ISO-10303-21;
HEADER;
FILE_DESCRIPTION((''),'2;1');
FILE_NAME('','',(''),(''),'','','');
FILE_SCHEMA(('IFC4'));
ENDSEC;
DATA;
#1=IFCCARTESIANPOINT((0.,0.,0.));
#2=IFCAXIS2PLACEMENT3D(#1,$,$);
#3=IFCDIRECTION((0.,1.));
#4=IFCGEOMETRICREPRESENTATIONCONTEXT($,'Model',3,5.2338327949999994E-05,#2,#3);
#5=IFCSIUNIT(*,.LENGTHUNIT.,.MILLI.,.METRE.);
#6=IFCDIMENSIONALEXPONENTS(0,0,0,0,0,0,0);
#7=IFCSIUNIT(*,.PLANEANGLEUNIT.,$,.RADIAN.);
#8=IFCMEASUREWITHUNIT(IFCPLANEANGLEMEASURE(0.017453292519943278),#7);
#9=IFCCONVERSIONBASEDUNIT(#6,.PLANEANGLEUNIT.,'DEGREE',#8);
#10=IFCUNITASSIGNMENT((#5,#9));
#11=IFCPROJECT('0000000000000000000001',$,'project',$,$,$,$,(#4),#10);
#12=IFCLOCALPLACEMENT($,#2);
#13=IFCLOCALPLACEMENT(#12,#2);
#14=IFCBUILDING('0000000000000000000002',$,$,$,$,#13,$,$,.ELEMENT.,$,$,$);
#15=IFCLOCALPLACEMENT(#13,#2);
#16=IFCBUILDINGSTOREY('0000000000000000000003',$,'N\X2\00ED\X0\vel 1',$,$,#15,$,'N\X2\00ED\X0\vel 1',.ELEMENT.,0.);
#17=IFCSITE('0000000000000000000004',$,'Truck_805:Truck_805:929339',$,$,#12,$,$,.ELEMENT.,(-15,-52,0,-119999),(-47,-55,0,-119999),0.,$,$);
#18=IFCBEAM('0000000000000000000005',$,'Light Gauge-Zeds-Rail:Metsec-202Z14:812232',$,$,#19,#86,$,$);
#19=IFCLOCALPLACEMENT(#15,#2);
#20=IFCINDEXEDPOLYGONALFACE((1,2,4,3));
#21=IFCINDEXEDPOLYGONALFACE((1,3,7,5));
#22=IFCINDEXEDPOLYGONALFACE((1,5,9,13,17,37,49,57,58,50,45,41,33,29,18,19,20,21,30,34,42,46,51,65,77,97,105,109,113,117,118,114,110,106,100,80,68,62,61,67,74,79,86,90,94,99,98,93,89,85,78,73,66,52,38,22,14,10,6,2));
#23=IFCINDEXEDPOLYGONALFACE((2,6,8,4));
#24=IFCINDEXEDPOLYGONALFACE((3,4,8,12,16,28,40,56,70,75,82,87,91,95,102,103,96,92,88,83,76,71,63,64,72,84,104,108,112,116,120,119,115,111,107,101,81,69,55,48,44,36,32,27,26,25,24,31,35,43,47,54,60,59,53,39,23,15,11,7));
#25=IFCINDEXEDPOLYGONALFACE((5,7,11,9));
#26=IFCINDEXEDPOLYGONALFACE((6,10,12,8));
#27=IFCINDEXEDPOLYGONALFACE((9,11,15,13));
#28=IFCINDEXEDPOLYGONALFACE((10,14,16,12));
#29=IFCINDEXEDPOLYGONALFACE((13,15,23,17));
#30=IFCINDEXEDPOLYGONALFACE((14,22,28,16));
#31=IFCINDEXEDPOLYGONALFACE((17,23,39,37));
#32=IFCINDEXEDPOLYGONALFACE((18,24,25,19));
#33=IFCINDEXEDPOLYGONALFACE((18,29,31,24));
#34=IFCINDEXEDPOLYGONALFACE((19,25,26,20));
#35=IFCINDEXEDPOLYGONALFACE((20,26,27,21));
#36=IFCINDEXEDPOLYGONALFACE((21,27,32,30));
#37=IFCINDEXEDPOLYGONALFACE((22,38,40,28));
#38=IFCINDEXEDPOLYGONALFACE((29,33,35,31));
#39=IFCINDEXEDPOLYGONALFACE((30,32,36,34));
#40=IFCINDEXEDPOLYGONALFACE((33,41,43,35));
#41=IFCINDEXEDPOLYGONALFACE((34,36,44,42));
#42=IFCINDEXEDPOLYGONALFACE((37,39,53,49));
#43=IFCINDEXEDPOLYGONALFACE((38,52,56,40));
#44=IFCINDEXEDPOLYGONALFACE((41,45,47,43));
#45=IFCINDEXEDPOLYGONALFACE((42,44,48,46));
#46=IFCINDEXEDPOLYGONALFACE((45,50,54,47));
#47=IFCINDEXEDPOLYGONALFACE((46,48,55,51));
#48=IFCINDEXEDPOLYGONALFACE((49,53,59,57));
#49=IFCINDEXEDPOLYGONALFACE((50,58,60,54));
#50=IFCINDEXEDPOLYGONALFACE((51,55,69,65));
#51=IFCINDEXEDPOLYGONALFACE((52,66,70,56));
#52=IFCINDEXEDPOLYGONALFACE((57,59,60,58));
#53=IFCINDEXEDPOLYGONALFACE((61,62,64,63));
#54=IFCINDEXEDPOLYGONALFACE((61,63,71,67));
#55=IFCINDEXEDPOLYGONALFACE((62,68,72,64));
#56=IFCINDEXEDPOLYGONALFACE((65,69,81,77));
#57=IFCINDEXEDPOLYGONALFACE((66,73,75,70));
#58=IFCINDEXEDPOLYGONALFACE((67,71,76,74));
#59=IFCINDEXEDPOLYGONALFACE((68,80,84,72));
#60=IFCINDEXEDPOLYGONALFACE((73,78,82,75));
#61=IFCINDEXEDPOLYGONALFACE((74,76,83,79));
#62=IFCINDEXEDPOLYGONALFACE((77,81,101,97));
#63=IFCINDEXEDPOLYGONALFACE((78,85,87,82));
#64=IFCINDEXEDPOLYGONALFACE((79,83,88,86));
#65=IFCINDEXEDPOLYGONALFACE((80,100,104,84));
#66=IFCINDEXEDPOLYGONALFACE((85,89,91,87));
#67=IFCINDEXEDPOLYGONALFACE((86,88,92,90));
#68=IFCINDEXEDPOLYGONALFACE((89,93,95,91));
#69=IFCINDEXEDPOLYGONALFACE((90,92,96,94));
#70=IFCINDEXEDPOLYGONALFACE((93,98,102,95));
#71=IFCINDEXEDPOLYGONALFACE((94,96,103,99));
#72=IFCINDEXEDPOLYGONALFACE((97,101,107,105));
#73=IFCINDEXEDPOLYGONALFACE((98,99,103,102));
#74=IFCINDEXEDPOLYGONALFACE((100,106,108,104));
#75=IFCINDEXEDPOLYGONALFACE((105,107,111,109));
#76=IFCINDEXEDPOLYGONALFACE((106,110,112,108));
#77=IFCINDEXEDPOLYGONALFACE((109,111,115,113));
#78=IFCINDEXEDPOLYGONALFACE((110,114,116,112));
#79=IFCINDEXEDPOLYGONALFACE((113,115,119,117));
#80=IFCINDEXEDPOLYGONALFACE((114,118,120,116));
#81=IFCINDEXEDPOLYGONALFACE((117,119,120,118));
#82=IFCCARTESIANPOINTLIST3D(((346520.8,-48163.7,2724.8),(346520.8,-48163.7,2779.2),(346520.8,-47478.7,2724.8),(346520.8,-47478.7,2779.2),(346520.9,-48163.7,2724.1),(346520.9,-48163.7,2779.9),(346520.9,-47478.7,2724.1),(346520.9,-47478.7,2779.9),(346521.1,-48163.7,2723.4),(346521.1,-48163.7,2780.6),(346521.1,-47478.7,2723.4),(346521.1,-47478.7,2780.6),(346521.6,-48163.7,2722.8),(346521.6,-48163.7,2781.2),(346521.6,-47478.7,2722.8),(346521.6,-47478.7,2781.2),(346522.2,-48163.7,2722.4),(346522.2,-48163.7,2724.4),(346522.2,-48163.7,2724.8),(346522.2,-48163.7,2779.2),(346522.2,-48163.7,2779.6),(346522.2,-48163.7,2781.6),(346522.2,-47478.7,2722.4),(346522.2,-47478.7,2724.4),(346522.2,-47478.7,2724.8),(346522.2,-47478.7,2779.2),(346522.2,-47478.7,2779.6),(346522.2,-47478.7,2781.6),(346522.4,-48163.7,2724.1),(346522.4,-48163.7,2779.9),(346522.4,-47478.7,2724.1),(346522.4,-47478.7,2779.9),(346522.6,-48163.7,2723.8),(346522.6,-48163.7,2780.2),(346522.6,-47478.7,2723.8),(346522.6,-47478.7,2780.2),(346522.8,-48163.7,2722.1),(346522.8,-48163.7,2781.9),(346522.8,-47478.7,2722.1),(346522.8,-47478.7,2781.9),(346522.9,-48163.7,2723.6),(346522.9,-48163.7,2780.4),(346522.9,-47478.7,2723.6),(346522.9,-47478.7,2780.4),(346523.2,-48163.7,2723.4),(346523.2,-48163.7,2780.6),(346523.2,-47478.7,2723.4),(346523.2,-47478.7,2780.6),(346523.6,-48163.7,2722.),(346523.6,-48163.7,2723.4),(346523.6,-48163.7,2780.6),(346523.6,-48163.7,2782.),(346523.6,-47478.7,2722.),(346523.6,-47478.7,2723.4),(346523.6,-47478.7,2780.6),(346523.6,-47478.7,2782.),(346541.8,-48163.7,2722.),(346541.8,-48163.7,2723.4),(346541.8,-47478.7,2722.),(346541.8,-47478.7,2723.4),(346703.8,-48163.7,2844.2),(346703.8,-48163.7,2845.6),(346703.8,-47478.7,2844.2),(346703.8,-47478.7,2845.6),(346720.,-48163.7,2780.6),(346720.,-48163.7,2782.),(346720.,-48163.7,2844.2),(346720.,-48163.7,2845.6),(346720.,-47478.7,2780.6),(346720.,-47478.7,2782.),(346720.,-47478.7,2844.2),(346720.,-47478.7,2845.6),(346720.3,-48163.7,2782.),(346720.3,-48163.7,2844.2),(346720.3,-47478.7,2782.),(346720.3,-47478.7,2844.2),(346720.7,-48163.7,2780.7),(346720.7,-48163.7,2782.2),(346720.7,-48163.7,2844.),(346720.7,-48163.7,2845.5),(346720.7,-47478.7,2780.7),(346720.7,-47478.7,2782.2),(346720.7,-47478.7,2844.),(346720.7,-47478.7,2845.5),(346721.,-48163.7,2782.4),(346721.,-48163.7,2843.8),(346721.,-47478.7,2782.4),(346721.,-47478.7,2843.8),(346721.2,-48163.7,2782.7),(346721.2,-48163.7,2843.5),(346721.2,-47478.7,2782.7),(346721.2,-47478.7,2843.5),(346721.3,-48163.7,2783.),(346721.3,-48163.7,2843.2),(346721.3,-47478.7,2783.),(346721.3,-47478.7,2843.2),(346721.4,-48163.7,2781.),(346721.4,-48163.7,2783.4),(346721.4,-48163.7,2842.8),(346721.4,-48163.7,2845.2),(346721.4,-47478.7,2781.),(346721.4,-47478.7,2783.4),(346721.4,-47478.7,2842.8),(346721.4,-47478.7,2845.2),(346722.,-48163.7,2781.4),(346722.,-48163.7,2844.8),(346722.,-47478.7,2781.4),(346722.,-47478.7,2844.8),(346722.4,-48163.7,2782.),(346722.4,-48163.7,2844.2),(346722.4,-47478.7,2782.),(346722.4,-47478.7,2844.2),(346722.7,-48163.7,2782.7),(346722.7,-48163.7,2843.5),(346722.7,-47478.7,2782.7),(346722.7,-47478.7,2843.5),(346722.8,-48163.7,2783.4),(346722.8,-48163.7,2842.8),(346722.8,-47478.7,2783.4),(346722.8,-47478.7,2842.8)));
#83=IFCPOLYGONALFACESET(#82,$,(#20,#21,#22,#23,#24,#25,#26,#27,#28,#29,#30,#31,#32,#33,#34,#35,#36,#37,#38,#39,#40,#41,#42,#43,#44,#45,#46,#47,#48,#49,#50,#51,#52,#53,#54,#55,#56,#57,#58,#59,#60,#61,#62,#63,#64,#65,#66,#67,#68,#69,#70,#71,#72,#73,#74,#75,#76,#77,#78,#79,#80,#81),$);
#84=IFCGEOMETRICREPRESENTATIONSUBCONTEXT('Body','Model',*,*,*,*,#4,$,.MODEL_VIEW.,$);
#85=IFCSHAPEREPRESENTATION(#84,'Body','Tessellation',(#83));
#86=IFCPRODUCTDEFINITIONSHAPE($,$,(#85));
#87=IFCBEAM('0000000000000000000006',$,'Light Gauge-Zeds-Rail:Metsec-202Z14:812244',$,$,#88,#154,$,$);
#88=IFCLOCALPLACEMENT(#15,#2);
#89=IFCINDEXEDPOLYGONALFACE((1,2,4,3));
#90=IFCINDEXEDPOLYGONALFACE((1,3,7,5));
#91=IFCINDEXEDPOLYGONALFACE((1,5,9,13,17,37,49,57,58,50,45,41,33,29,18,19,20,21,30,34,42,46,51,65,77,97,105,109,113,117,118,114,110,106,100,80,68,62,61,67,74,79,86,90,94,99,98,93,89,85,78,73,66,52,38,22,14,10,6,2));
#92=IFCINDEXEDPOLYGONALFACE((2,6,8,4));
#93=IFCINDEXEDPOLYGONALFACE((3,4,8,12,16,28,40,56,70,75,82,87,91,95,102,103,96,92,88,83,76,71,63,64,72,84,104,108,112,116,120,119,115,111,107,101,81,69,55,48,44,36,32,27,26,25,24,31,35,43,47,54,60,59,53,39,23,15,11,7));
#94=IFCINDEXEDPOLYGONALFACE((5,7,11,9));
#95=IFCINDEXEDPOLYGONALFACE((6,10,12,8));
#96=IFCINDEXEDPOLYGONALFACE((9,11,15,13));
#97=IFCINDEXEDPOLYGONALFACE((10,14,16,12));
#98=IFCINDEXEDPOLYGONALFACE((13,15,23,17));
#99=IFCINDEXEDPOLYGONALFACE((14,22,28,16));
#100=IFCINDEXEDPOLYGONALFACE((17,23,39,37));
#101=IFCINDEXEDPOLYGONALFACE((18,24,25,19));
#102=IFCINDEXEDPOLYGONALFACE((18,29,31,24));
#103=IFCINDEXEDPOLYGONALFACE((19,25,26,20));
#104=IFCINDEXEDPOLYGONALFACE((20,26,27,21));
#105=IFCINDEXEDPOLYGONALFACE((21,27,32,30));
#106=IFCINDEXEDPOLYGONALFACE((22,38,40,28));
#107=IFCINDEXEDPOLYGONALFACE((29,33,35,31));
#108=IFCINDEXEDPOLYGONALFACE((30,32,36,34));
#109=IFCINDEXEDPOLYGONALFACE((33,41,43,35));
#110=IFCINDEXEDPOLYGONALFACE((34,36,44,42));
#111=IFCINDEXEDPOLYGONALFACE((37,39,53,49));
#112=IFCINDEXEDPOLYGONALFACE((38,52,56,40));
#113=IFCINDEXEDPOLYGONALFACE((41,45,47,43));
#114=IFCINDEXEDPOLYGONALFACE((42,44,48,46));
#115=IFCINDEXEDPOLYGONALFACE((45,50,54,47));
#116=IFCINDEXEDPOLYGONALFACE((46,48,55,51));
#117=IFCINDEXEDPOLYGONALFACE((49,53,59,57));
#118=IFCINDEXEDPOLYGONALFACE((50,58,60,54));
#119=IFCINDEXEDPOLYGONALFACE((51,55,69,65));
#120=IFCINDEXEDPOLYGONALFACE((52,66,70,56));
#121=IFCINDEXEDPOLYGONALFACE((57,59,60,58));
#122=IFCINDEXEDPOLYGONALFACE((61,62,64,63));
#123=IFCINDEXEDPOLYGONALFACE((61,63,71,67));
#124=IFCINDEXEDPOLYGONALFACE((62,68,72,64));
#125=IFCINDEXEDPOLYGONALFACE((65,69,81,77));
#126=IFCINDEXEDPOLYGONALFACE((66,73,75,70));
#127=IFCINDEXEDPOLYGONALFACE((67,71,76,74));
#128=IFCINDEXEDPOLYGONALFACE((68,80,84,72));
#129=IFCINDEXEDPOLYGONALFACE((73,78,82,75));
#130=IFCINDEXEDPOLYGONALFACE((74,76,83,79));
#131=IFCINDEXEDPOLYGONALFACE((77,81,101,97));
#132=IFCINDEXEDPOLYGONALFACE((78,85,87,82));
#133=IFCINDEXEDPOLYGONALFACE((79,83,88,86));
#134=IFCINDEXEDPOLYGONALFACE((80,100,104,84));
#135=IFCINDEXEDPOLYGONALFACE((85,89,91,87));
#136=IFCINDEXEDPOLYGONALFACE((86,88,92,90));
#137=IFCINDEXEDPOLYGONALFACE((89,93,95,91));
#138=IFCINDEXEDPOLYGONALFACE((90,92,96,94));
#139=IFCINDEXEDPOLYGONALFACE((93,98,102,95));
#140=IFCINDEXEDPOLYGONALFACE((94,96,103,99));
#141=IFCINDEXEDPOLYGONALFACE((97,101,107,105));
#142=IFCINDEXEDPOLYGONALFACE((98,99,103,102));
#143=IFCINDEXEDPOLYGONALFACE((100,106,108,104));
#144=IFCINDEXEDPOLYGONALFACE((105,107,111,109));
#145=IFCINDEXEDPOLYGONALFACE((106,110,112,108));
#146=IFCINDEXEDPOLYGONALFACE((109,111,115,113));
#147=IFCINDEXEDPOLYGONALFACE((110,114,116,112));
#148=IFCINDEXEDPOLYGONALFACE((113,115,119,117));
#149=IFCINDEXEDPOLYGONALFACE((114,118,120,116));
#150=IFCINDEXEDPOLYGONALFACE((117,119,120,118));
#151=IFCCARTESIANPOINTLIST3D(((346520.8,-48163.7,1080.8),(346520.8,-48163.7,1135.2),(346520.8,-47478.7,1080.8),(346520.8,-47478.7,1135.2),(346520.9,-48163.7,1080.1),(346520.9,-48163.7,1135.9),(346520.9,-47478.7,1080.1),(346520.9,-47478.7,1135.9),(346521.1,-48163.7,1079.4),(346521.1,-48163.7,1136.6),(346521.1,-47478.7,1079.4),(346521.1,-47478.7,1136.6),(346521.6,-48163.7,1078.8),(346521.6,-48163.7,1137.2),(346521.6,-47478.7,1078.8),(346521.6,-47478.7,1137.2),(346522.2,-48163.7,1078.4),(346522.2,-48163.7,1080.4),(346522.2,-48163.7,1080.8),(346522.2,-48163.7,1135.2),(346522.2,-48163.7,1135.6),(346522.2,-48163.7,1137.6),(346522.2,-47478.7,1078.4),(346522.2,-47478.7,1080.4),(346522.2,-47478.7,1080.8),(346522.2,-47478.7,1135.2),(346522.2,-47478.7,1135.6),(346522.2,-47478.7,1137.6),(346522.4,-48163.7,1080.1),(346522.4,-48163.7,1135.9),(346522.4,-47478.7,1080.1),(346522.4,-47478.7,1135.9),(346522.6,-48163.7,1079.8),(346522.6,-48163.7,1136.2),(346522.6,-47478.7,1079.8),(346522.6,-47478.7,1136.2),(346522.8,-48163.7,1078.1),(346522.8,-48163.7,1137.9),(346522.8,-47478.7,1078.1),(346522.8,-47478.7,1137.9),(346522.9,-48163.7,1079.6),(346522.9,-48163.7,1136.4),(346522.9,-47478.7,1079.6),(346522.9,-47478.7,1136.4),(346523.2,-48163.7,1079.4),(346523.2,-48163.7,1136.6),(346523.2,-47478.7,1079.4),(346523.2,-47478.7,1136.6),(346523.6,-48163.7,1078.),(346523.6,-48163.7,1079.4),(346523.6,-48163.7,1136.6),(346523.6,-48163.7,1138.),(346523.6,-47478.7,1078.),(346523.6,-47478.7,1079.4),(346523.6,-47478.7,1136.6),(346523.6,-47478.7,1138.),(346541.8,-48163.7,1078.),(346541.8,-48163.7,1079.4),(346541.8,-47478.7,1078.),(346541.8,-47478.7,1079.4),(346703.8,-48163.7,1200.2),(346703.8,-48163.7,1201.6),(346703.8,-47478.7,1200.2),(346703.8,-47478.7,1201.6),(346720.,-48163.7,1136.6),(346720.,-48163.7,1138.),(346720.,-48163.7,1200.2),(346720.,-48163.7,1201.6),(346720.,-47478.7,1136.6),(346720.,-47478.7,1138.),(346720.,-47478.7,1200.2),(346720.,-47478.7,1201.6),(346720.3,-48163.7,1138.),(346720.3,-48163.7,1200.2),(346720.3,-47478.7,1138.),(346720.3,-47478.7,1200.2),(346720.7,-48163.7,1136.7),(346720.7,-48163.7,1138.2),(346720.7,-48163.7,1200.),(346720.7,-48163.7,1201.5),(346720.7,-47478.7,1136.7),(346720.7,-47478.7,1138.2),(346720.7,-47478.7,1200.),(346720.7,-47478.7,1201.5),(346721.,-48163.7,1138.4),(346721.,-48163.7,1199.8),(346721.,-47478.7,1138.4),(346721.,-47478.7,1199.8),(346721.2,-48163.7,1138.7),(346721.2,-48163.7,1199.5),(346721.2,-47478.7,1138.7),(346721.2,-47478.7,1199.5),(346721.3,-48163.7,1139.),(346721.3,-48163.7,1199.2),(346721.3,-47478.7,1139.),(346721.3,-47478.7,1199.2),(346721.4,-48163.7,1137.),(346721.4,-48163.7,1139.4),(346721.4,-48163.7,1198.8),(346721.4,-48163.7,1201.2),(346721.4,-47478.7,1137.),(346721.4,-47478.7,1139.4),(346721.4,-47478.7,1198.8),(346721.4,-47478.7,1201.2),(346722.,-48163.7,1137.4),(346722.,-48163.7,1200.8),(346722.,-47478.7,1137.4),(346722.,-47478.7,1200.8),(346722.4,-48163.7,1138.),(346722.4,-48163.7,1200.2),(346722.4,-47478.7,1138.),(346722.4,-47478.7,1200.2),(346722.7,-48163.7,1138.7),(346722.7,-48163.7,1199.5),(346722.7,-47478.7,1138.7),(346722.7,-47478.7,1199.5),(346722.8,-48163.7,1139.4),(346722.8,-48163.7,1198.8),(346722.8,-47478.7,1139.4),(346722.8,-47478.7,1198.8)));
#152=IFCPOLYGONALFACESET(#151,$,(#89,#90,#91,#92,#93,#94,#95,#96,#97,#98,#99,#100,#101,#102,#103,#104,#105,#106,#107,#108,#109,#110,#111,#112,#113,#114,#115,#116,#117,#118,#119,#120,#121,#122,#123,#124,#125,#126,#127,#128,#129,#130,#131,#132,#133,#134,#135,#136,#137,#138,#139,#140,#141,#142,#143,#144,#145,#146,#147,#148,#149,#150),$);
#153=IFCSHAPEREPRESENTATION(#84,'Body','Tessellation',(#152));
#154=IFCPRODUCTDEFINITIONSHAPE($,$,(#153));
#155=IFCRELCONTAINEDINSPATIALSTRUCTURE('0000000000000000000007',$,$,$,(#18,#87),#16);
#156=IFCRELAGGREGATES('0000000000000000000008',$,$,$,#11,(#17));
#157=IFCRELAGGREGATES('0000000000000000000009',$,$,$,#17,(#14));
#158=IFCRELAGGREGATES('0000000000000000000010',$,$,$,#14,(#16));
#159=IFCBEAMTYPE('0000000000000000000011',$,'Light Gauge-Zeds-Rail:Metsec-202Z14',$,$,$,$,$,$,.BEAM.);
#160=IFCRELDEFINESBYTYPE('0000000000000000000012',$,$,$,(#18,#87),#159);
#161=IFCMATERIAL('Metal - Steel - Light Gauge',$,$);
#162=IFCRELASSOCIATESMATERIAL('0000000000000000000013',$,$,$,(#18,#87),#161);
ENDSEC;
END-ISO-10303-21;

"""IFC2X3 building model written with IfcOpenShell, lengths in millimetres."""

from ifc_helpers import new_model, entity, si_unit, converted_unit, direction, frame, frame_2d, origin, place, context, subcontext, project, spatial, polyline, circle_curve, parameter, trimmed, segment, composite_curve, outline, extrude, material, type_object, element, save


model = new_model("IFC2X3")

# Units and contexts
model_context = context("Model", 3, precision=5.2338327949999994e-05, world=origin(), true_north=direction((0.0, 1.0)))
body_context = subcontext(model_context, "Body", "Model", "MODEL_VIEW")
ifc_project = project(units=[si_unit("LENGTHUNIT", "METRE", prefix="MILLI"), converted_unit("PLANEANGLEUNIT", "DEGREE", entity("IfcPlaneAngleMeasure", 0.017453292519943278), si_unit("PLANEANGLEUNIT", "RADIAN"), dimensions=[0, 0, 0, 0, 0, 0, 0])], contexts=[model_context])

# Site, building, storey
site_placement = place(None, origin())
site = spatial("IfcSite", under=ifc_project, at=site_placement, Name="Truck_805:Truck_805:929339", CompositionType="ELEMENT", RefLatitude=(-15, -52, 0, -119999), RefLongitude=(-47, -55, 0, -119999), RefElevation=0.0)
building_placement = place(site_placement, origin())
building = spatial("IfcBuilding", under=site, at=building_placement, CompositionType="ELEMENT")
storey_placement = place(building_placement, origin())
storey = spatial("IfcBuildingStorey", under=building, at=storey_placement, Name="Nível 1", LongName="Nível 1", CompositionType="ELEMENT", Elevation=0.0)

# Beams
ifc_material_1 = material(Name="Metal - Steel - Light Gauge")
beam_type_1 = type_object("IfcBeamType", Name="Light Gauge-Zeds-Rail:Metsec-202Z14", PredefinedType="BEAM")
beam_1_placement = place(storey_placement, frame((346622.7, -48163.7, 2845.6), z_axis=(0.0, 0.0, 1.0), x_axis=(0.0, 1.0, 0.0)))
element("IfcBeam", 1, at=beam_1_placement, inside=storey, type_object=beam_type_1, material=ifc_material_1, Name="Light Gauge-Zeds-Rail:Metsec-202Z14:812232", context=body_context, shape_type="SweptSolid", body=[
    extrude(outline(composite_curve([segment(polyline([(-60.0, -100.8), (-0.6, -100.8)]), True, "CONTINUOUS"), segment(trimmed(circle_curve(frame_2d((-0.6, -98.0), x_axis=(0.0, -1.0)), 2.8), [parameter(0.0)], [parameter(90.0)], True, "PARAMETER"), True, "CONTINUOUS"), segment(polyline([(2.2, -98.0), (2.2, 98.4)]), True, "CONTINUOUS"), segment(trimmed(circle_curve(frame_2d((3.6, 98.4), x_axis=(-1.0, 0.0)), 1.4), [parameter(270.0)], [parameter(0.0)], True, "PARAMETER"), False, "CONTINUOUS"), segment(polyline([(3.6, 99.8), (58.0, 99.8)]), True, "CONTINUOUS"), segment(trimmed(circle_curve(frame_2d((58.0, 98.4), x_axis=(0.0, 1.0)), 1.4), [parameter(270.0)], [parameter(0.0)], True, "PARAMETER"), False, "CONTINUOUS"), segment(polyline([(59.4, 98.4), (59.4, 80.2)]), True, "CONTINUOUS"), segment(polyline([(59.4, 80.2), (60.8, 80.2)]), True, "CONTINUOUS"), segment(polyline([(60.8, 80.2), (60.8, 98.4)]), True, "CONTINUOUS"), segment(trimmed(circle_curve(frame_2d((58.0, 98.4), x_axis=(1.0, 0.0)), 2.8), [parameter(0.0)], [parameter(90.0)], True, "PARAMETER"), True, "CONTINUOUS"), segment(polyline([(58.0, 101.2), (3.6, 101.2)]), True, "CONTINUOUS"), segment(trimmed(circle_curve(frame_2d((3.6, 98.4), x_axis=(0.0, 1.0)), 2.8), [parameter(0.0)], [parameter(90.0)], True, "PARAMETER"), True, "CONTINUOUS"), segment(polyline([(0.8, 98.4), (0.8, -98.0)]), True, "CONTINUOUS"), segment(trimmed(circle_curve(frame_2d((-0.6, -98.0), x_axis=(1.0, 0.0)), 1.4), [parameter(270.0)], [parameter(0.0)], True, "PARAMETER"), False, "CONTINUOUS"), segment(polyline([(-0.6, -99.4), (-60.0, -99.4)]), True, "CONTINUOUS"), segment(trimmed(circle_curve(frame_2d((-60.0, -98.0), x_axis=(0.0, -1.0)), 1.4), [parameter(270.0)], [parameter(0.0)], True, "PARAMETER"), False, "CONTINUOUS"), segment(polyline([(-61.4, -98.0), (-61.4, -81.8)]), True, "CONTINUOUS"), segment(polyline([(-61.4, -81.8), (-62.8, -81.8)]), True, "CONTINUOUS"), segment(polyline([(-62.8, -81.8), (-62.8, -98.0)]), True, "CONTINUOUS"), segment(trimmed(circle_curve(frame_2d((-60.0, -98.0), x_axis=(-1.0, 0.0)), 2.8), [parameter(0.0)], [parameter(90.0)], True, "PARAMETER"), True, "CONTINUOUS")], self_intersect=False)), frame((0.0, 0.7, -62.8), z_axis=(1.0, 0.0, 0.0), x_axis=(0.0, 0.0, -1.0)), (0.0, 0.0, 1.0), 685.0),
])
beam_2_placement = place(storey_placement, frame((346622.7, -48163.7, 1201.6), z_axis=(0.0, 0.0, 1.0), x_axis=(0.0, 1.0, 0.0)))
element("IfcBeam", 2, at=beam_2_placement, inside=storey, type_object=beam_type_1, material=ifc_material_1, Name="Light Gauge-Zeds-Rail:Metsec-202Z14:812244", context=body_context, shape_type="SweptSolid", body=[
    extrude(outline(composite_curve([segment(polyline([(-60.0, -100.8), (-0.6, -100.8)]), True, "CONTINUOUS"), segment(trimmed(circle_curve(frame_2d((-0.6, -98.0), x_axis=(0.0, -1.0)), 2.8), [parameter(0.0)], [parameter(90.0)], True, "PARAMETER"), True, "CONTINUOUS"), segment(polyline([(2.2, -98.0), (2.2, 98.4)]), True, "CONTINUOUS"), segment(trimmed(circle_curve(frame_2d((3.6, 98.4), x_axis=(-1.0, 0.0)), 1.4), [parameter(270.0)], [parameter(0.0)], True, "PARAMETER"), False, "CONTINUOUS"), segment(polyline([(3.6, 99.8), (58.0, 99.8)]), True, "CONTINUOUS"), segment(trimmed(circle_curve(frame_2d((58.0, 98.4), x_axis=(0.0, 1.0)), 1.4), [parameter(270.0)], [parameter(0.0)], True, "PARAMETER"), False, "CONTINUOUS"), segment(polyline([(59.4, 98.4), (59.4, 80.2)]), True, "CONTINUOUS"), segment(polyline([(59.4, 80.2), (60.8, 80.2)]), True, "CONTINUOUS"), segment(polyline([(60.8, 80.2), (60.8, 98.4)]), True, "CONTINUOUS"), segment(trimmed(circle_curve(frame_2d((58.0, 98.4), x_axis=(1.0, 0.0)), 2.8), [parameter(0.0)], [parameter(90.0)], True, "PARAMETER"), True, "CONTINUOUS"), segment(polyline([(58.0, 101.2), (3.6, 101.2)]), True, "CONTINUOUS"), segment(trimmed(circle_curve(frame_2d((3.6, 98.4), x_axis=(0.0, 1.0)), 2.8), [parameter(0.0)], [parameter(90.0)], True, "PARAMETER"), True, "CONTINUOUS"), segment(polyline([(0.8, 98.4), (0.8, -98.0)]), True, "CONTINUOUS"), segment(trimmed(circle_curve(frame_2d((-0.6, -98.0), x_axis=(1.0, 0.0)), 1.4), [parameter(270.0)], [parameter(0.0)], True, "PARAMETER"), False, "CONTINUOUS"), segment(polyline([(-0.6, -99.4), (-60.0, -99.4)]), True, "CONTINUOUS"), segment(trimmed(circle_curve(frame_2d((-60.0, -98.0), x_axis=(0.0, -1.0)), 1.4), [parameter(270.0)], [parameter(0.0)], True, "PARAMETER"), False, "CONTINUOUS"), segment(polyline([(-61.4, -98.0), (-61.4, -81.8)]), True, "CONTINUOUS"), segment(polyline([(-61.4, -81.8), (-62.8, -81.8)]), True, "CONTINUOUS"), segment(polyline([(-62.8, -81.8), (-62.8, -98.0)]), True, "CONTINUOUS"), segment(trimmed(circle_curve(frame_2d((-60.0, -98.0), x_axis=(-1.0, 0.0)), 2.8), [parameter(0.0)], [parameter(90.0)], True, "PARAMETER"), True, "CONTINUOUS")], self_intersect=False)), frame((0.0, 0.7, -62.8), z_axis=(1.0, 0.0, 0.0), x_axis=(0.0, 0.0, -1.0)), (0.0, 0.0, 1.0), 685.0),
])

save(model, "model.ifc")
